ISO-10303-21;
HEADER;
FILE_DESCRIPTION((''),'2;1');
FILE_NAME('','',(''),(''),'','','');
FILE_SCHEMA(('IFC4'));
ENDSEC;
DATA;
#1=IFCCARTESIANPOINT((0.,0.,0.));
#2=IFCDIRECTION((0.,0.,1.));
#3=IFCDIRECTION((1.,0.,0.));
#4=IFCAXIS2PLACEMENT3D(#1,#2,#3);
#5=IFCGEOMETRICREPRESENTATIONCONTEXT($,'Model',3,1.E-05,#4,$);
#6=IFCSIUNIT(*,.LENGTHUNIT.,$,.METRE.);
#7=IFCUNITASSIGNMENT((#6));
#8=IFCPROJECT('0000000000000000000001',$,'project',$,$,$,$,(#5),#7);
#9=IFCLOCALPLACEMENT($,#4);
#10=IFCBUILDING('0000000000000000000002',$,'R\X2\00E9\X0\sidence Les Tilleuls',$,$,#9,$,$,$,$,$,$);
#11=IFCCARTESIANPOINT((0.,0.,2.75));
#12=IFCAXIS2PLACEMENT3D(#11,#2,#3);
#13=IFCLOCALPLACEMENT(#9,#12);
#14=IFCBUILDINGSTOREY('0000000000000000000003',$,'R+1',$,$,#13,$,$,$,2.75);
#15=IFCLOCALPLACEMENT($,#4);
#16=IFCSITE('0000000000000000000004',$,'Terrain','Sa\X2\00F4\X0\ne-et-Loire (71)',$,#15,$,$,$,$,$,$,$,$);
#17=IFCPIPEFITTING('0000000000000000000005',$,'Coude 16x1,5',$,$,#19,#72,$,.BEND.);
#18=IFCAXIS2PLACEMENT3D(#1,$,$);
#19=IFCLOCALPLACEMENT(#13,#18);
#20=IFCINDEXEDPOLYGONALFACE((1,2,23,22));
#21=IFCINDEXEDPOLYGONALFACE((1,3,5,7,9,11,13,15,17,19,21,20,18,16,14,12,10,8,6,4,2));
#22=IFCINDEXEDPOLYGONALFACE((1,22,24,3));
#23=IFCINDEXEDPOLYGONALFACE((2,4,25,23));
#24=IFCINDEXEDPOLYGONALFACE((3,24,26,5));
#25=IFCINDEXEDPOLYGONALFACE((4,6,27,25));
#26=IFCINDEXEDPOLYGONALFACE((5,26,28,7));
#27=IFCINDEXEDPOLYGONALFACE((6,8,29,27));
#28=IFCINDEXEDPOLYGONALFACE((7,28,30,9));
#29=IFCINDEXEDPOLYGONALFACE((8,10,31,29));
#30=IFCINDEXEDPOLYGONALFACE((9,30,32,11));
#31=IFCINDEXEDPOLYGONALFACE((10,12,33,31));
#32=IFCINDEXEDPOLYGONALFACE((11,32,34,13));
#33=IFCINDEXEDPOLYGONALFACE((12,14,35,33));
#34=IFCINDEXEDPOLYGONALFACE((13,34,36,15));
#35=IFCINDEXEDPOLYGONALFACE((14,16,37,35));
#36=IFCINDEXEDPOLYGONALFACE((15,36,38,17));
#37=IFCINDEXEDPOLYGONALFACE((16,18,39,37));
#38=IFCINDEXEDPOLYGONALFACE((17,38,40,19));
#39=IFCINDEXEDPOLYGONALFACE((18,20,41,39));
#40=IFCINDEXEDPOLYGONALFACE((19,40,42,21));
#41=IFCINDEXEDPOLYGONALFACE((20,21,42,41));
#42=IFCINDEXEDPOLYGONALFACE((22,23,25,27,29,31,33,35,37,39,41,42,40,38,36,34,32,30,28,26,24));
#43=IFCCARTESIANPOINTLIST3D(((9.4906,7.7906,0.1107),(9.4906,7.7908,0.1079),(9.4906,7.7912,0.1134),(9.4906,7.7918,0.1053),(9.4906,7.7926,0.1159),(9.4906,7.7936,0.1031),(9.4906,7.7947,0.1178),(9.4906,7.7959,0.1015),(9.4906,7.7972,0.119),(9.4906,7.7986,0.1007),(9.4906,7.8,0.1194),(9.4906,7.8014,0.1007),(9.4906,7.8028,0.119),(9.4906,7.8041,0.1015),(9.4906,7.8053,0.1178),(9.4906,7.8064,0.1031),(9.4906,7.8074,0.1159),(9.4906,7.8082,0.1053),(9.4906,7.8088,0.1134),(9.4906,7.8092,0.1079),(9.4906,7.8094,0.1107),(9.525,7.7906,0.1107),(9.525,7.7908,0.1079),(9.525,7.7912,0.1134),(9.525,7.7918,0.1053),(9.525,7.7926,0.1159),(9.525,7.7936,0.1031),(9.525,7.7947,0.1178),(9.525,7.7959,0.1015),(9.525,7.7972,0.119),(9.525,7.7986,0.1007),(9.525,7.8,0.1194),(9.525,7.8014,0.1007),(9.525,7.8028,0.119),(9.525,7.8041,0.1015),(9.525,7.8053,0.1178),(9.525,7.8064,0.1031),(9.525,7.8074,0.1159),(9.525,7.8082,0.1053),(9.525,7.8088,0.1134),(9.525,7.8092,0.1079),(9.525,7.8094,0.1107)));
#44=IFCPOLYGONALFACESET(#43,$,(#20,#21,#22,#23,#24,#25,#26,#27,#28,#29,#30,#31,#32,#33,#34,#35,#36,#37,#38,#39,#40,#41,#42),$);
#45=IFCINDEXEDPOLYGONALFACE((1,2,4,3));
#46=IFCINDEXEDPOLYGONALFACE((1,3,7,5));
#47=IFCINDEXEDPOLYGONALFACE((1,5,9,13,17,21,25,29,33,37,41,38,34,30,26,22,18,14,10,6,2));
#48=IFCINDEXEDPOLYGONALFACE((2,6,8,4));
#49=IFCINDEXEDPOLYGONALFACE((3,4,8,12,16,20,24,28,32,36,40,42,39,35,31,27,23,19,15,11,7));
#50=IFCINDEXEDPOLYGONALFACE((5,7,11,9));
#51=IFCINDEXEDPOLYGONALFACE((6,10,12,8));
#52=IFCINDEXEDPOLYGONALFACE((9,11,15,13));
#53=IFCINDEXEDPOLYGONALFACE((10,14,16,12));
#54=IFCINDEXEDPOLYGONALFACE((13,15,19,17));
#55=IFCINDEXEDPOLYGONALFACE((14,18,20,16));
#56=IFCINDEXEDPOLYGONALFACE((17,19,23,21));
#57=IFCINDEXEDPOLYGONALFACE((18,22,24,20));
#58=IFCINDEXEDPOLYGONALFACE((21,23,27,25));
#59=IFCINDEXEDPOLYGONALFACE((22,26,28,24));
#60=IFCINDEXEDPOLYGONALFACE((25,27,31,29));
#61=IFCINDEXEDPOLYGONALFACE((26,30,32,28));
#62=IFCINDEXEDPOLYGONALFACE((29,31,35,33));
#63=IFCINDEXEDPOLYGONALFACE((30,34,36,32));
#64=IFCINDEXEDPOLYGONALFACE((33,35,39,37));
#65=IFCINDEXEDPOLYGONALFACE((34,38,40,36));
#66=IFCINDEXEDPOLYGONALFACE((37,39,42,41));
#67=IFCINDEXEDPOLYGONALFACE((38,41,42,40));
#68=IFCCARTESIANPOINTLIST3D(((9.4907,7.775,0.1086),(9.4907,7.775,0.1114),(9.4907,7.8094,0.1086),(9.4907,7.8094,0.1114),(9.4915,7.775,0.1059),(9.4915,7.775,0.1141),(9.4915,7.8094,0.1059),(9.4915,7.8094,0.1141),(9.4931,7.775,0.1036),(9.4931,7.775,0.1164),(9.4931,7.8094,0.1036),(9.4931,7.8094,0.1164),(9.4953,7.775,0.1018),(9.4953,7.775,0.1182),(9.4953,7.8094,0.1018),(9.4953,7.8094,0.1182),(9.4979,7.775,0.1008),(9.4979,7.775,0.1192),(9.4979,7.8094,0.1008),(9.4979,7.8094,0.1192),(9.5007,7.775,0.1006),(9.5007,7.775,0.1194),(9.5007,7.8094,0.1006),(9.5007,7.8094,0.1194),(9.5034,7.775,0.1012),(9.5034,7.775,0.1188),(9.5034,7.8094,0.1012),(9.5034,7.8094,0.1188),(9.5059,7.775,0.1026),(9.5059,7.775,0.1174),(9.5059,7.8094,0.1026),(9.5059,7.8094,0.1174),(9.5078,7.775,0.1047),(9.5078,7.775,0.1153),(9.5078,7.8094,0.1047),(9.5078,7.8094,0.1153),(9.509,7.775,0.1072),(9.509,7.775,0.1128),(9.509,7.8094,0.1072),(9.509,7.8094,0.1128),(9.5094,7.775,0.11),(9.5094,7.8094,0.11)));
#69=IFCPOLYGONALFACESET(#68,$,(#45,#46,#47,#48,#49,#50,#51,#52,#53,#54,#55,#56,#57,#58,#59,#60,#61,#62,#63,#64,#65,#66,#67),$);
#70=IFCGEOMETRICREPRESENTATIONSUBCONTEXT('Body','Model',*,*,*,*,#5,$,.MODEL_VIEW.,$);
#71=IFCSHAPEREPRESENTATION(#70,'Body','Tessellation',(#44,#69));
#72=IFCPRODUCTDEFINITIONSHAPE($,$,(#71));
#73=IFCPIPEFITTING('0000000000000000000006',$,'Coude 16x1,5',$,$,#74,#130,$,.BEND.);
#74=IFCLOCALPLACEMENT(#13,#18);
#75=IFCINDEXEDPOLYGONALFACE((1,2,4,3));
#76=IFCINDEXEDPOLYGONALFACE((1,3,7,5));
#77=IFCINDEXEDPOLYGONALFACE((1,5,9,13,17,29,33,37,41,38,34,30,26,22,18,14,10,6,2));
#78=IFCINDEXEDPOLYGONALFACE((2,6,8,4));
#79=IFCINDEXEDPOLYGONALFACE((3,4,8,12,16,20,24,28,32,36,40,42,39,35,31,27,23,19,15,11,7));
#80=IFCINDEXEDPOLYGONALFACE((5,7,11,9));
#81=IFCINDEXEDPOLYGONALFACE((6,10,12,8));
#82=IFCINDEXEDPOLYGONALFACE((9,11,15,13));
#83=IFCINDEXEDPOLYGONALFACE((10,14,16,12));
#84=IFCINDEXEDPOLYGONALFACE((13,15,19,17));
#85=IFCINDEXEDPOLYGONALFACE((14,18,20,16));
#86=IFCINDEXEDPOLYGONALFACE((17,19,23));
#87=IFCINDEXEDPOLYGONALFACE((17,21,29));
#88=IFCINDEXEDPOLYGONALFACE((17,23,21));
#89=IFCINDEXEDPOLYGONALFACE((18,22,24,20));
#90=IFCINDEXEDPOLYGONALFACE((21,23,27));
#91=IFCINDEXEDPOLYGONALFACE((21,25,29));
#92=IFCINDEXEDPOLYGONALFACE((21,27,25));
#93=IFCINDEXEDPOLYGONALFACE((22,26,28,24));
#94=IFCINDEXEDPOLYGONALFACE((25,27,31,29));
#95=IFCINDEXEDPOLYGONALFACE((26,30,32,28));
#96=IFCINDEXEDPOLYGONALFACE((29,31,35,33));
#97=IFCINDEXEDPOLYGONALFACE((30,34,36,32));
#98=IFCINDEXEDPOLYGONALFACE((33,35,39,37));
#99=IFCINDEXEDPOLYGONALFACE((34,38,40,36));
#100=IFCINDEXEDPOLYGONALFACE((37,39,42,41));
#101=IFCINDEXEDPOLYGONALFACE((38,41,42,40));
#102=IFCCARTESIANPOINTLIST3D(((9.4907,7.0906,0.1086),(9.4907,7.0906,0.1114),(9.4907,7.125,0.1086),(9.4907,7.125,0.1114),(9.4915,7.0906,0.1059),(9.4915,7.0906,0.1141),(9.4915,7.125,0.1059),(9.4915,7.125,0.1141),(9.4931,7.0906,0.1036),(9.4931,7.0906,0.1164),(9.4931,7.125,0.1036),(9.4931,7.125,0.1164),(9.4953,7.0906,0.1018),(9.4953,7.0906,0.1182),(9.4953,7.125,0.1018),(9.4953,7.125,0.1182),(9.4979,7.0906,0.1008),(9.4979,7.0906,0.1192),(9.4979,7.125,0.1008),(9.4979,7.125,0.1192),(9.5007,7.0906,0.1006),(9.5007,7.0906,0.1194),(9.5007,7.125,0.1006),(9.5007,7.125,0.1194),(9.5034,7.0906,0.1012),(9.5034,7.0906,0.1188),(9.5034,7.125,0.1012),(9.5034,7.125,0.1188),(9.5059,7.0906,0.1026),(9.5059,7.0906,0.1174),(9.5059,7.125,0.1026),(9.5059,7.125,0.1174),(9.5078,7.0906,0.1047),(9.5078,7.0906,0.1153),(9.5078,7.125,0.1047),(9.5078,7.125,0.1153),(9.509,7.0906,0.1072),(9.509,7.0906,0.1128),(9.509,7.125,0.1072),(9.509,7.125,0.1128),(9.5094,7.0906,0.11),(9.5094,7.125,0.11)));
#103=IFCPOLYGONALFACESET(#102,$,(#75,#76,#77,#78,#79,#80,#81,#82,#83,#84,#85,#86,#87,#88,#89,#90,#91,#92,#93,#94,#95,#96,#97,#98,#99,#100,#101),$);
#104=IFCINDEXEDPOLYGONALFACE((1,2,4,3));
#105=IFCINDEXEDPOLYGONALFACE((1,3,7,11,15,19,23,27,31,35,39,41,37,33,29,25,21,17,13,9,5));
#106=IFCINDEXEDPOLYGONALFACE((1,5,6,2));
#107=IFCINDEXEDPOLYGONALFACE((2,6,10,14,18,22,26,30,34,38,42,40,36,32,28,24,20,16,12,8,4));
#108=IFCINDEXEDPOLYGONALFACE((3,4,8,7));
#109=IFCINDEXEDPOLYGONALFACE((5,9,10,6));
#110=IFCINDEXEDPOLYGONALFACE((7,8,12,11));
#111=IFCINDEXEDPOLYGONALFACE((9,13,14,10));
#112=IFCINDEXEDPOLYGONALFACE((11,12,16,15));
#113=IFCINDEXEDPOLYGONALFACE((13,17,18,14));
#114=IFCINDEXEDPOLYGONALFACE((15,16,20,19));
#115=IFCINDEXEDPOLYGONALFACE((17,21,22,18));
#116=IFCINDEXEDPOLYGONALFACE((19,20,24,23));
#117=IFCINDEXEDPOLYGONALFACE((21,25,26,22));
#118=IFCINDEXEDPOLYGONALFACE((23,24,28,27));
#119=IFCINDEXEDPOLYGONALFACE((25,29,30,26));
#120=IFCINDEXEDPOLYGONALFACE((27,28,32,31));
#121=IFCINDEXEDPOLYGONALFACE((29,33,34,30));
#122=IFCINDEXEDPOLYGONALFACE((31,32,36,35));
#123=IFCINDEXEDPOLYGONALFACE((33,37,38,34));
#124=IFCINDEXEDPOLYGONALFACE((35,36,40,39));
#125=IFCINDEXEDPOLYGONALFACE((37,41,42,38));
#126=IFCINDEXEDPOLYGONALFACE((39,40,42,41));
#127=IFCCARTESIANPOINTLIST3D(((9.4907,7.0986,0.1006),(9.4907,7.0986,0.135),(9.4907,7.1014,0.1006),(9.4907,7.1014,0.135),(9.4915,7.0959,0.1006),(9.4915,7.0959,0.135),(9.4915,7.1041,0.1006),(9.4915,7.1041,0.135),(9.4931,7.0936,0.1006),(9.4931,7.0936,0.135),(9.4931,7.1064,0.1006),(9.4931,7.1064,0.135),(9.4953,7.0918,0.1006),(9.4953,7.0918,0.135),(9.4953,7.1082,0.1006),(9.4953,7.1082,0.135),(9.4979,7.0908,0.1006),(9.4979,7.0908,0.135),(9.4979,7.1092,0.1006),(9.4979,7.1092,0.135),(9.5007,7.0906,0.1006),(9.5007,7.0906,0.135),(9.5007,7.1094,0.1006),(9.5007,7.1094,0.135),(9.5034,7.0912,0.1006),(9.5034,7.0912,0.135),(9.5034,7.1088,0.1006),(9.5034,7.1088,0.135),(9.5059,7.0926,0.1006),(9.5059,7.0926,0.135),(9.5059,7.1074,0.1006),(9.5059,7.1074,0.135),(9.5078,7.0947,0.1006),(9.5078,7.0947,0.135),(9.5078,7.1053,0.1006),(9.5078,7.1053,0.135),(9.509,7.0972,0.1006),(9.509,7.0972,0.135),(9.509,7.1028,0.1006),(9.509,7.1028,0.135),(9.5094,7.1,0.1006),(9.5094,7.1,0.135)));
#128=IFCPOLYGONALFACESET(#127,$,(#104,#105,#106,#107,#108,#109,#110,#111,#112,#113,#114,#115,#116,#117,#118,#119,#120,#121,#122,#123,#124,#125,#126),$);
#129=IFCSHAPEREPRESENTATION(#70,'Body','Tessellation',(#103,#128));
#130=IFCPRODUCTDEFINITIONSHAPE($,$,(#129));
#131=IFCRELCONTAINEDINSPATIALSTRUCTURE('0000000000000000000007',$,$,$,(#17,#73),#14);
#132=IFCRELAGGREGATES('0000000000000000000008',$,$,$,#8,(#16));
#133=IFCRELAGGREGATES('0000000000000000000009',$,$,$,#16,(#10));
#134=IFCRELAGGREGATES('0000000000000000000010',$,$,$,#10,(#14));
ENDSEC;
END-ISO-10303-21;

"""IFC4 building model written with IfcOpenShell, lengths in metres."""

from ifc_helpers import new_model, si_unit, frame, origin_with_axes, place, context, subcontext, project, spatial, circle, extrude, element, save


model = new_model("IFC4")

# Units and contexts
model_context = context("Model", 3, precision=1e-05, world=origin_with_axes())
body_context = subcontext(model_context, "Body", "Model", "MODEL_VIEW")
ifc_project = project(units=[si_unit("LENGTHUNIT", "METRE")], contexts=[model_context])

# Site, building, storey
site_placement = place(None, origin_with_axes())
site = spatial("IfcSite", under=ifc_project, at=site_placement, Name="Terrain", Description="Saône-et-Loire (71)")
building_placement = place(None, origin_with_axes())
building = spatial("IfcBuilding", under=site, at=building_placement, Name="Résidence Les Tilleuls")
storey_placement = place(building_placement, frame((0.0, 0.0, 2.75), z_axis=(0.0, 0.0, 1.0), x_axis=(1.0, 0.0, 0.0)))
storey = spatial("IfcBuildingStorey", under=building, at=storey_placement, Name="R+1", Elevation=2.75)

# Pipe fittings
pipe_fitting_1_placement = place(storey_placement, frame((9.5, 7.8, 0.11), z_axis=(0.0, 0.0, 1.0), x_axis=(1.0, 0.0, 0.0)))
element("IfcPipeFitting", 1, at=pipe_fitting_1_placement, inside=storey, Name="Coude 16x1,5", PredefinedType="BEND", context=body_context, shape_type="SweptSolid", body=[
    extrude(circle(Radius=0.0094), frame((-0.0094, 0.0, 0.0), z_axis=(1.0, 0.0, 0.0), x_axis=(0.0, 0.0, 1.0)), (0.0, 0.0, 1.0), 0.0344),
    extrude(circle(Radius=0.0094), frame((0.0, 0.0094, 0.0), z_axis=(0.0, -1.0, 0.0), x_axis=(1.0, 0.0, 0.0)), (0.0, 0.0, 1.0), 0.0344),
])
pipe_fitting_2_placement = place(storey_placement, frame((9.5, 7.1, 0.11), z_axis=(0.0, 0.0, 1.0), x_axis=(1.0, 0.0, 0.0)))
element("IfcPipeFitting", 2, at=pipe_fitting_2_placement, inside=storey, Name="Coude 16x1,5", PredefinedType="BEND", context=body_context, shape_type="SweptSolid", body=[
    extrude(circle(Radius=0.0094), frame((0.0, -0.0094, 0.0), z_axis=(0.0, 1.0, 0.0), x_axis=(1.0, 0.0, 0.0)), (0.0, 0.0, 1.0), 0.0344),
    extrude(circle(Radius=0.0094), frame((0.0, 0.0, -0.0094), z_axis=(0.0, 0.0, 1.0), x_axis=(1.0, 0.0, 0.0)), (0.0, 0.0, 1.0), 0.0344),
])

save(model, "model.ifc")
